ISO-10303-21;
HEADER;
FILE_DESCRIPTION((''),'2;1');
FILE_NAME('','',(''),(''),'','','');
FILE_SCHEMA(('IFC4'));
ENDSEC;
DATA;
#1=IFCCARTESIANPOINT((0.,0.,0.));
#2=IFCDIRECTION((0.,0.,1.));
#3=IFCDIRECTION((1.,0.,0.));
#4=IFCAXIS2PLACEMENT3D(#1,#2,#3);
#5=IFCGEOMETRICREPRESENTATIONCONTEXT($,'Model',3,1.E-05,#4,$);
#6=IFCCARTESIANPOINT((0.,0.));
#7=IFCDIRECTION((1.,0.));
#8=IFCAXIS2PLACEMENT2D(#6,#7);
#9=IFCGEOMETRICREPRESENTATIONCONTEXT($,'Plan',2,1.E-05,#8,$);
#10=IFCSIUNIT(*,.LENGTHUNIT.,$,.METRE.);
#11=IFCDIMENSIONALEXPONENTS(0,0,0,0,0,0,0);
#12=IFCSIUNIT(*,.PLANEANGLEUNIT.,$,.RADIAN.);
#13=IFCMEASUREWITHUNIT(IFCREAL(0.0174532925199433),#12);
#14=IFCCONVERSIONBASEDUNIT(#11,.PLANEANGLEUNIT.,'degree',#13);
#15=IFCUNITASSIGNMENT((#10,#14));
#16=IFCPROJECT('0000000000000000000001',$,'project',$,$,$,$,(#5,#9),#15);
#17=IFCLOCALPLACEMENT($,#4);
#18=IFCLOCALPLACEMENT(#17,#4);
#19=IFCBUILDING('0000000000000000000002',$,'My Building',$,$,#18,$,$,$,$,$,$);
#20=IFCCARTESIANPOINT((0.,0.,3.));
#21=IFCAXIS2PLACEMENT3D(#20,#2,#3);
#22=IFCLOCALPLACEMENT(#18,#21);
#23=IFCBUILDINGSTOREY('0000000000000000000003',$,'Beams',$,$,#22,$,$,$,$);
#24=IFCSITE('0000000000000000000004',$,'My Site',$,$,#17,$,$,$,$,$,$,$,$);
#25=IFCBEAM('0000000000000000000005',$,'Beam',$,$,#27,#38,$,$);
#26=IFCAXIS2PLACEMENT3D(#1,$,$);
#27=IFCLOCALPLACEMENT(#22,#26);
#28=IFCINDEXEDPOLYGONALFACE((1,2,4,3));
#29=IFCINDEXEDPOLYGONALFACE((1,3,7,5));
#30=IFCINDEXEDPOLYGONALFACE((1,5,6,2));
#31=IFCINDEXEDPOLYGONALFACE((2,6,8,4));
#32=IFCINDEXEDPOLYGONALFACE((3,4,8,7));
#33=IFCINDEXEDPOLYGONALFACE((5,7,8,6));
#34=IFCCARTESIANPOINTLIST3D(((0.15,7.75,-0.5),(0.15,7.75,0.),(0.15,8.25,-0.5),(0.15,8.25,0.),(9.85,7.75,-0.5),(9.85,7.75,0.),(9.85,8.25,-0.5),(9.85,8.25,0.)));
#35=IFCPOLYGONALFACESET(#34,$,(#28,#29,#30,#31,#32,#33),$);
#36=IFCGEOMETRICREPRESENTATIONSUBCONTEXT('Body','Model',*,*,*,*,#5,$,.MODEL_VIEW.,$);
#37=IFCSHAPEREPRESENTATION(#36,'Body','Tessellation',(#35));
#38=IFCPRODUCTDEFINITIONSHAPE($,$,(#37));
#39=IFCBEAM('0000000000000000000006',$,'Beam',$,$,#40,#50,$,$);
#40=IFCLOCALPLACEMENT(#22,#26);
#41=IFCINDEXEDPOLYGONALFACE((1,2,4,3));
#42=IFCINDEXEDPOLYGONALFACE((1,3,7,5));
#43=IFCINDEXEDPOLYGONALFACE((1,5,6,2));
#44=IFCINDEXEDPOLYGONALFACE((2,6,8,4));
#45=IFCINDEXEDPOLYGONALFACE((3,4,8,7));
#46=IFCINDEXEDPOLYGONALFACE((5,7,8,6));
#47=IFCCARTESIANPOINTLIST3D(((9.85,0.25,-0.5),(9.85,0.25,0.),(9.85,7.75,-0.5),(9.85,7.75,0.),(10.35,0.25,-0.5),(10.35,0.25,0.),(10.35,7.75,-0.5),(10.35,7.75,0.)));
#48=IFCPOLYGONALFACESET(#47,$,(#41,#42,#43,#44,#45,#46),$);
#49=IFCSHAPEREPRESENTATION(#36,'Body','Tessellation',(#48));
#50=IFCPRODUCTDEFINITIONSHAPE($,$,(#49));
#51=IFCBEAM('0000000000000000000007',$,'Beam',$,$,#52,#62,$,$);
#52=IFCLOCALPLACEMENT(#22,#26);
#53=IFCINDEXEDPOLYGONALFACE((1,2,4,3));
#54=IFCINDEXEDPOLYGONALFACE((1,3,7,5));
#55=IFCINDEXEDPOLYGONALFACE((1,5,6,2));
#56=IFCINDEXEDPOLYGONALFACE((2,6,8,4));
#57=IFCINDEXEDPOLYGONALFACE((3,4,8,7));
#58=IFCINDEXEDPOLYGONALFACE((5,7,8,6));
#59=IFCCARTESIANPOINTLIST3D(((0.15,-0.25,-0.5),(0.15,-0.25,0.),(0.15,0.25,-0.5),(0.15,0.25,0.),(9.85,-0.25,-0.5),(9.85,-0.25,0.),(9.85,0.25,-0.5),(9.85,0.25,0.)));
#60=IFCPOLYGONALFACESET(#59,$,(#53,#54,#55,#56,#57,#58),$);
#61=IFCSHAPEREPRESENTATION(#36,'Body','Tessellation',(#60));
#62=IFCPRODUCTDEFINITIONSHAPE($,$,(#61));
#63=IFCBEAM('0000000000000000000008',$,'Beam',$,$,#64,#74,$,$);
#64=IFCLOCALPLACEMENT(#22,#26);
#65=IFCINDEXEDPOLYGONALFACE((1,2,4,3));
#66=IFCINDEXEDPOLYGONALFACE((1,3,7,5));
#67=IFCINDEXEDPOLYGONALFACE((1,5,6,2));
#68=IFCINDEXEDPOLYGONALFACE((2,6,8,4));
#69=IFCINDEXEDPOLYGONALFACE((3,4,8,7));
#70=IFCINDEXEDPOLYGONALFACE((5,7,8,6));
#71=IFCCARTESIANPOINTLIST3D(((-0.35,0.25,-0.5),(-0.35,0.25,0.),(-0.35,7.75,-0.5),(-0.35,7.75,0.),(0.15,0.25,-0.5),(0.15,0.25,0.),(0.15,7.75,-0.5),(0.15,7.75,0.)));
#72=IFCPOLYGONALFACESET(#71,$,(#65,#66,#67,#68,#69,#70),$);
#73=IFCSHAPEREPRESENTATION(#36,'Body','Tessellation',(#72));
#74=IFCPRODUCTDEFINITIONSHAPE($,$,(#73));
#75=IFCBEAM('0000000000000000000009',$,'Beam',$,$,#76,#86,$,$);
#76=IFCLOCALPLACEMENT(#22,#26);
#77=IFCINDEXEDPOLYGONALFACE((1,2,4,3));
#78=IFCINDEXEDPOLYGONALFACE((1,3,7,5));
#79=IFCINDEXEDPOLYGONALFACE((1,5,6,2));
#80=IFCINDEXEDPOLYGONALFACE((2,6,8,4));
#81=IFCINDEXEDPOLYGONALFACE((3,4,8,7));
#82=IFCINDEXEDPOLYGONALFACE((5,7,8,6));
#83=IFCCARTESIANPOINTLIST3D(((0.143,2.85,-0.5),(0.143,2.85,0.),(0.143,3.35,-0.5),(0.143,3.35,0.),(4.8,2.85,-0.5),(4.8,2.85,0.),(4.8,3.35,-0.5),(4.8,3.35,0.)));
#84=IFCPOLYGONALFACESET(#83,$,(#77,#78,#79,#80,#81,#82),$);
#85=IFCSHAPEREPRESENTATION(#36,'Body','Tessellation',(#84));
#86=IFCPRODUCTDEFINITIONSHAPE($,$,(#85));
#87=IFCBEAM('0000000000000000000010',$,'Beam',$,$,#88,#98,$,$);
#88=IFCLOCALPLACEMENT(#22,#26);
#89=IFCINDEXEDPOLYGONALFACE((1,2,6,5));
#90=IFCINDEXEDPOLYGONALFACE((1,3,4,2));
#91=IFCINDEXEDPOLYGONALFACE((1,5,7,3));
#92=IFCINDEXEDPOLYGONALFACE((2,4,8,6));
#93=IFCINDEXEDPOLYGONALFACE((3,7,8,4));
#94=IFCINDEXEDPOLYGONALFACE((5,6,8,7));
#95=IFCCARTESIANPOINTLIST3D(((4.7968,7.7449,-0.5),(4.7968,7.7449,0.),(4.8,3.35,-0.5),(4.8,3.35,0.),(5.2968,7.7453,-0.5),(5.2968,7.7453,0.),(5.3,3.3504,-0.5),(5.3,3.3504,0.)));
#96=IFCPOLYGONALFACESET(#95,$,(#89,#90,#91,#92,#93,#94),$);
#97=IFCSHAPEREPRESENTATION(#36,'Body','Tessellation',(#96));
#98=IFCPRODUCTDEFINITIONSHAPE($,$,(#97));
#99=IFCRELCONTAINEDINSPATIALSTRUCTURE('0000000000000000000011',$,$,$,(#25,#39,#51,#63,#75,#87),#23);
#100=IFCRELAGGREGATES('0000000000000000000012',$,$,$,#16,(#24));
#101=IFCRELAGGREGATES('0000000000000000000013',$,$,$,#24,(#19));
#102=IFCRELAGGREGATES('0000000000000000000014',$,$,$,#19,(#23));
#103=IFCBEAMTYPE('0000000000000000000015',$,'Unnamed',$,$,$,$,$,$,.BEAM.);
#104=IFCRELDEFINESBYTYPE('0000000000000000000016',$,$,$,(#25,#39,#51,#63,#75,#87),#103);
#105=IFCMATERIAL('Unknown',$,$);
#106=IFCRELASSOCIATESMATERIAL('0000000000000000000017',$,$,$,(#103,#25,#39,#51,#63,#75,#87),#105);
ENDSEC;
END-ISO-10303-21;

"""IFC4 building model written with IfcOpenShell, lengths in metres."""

from ifc_helpers import new_model, entity, si_unit, converted_unit, frame, origin_with_axes, origin_2d_with_axis, place, context, subcontext, project, spatial, rectangle, extrude, material, material_profile, profile_set, profile_usage, type_object, element, save


model = new_model("IFC4")

# Units and contexts
model_context = context("Model", 3, precision=1e-05, world=origin_with_axes())
plan_context = context("Plan", 2, precision=1e-05, world=origin_2d_with_axis())
body_context = subcontext(model_context, "Body", "Model", "MODEL_VIEW")
ifc_project = project(units=[si_unit("LENGTHUNIT", "METRE"), converted_unit("PLANEANGLEUNIT", "degree", entity("IfcReal", 0.0174532925199433), si_unit("PLANEANGLEUNIT", "RADIAN"), dimensions=[0, 0, 0, 0, 0, 0, 0])], contexts=[model_context, plan_context])

# Site, building, storey
site_placement = place(None, origin_with_axes())
site = spatial("IfcSite", under=ifc_project, at=site_placement, Name="My Site")
building_placement = place(site_placement, origin_with_axes())
building = spatial("IfcBuilding", under=site, at=building_placement, Name="My Building")
storey_placement = place(building_placement, frame((0.0, 0.0, 3.0), z_axis=(0.0, 0.0, 1.0), x_axis=(1.0, 0.0, 0.0)))
storey = spatial("IfcBuildingStorey", under=building, at=storey_placement, Name="Beams")

# Beams
ifc_material = material(Name="Unknown")
ifc_material_profile = material_profile(ifc_material, rectangle(XDim=0.5, YDim=0.5))
ifc_profile_set = profile_set([ifc_material_profile])
ifc_profile_usage_1 = profile_usage(ifc_profile_set, cardinal=5)
beam_type = type_object("IfcBeamType", Name="Unnamed", PredefinedType="BEAM", material=ifc_profile_set)
beam_1_placement = place(storey_placement, frame((0.15, 8.0, -0.25), z_axis=(1.0, 0.0, 0.0), x_axis=(0.0, 1.0, 0.0)))
element("IfcBeam", 1, at=beam_1_placement, inside=storey, type_object=beam_type, material=ifc_profile_usage_1, Name="Beam", context=body_context, shape_type="SweptSolid", body=[
    extrude(rectangle(XDim=0.5, YDim=0.5), origin_with_axes(), (0.0, 0.0, 1.0), 9.7),
])
ifc_profile_usage_2 = profile_usage(ifc_profile_set, cardinal=5)
beam_2_placement = place(storey_placement, frame((10.1, 7.75, -0.25), z_axis=(0.0, -1.0, 0.0), x_axis=(1.0, 0.0, 0.0)))
element("IfcBeam", 2, at=beam_2_placement, inside=storey, type_object=beam_type, material=ifc_profile_usage_2, Name="Beam", context=body_context, shape_type="SweptSolid", body=[
    extrude(rectangle(XDim=0.5, YDim=0.5), origin_with_axes(), (0.0, 0.0, 1.0), 7.5),
])
ifc_profile_usage_3 = profile_usage(ifc_profile_set, cardinal=5)
beam_3_placement = place(storey_placement, frame((0.15, 0.0, -0.25), z_axis=(1.0, 0.0, 0.0), x_axis=(0.0, 1.0, 0.0)))
element("IfcBeam", 3, at=beam_3_placement, inside=storey, type_object=beam_type, material=ifc_profile_usage_3, Name="Beam", context=body_context, shape_type="SweptSolid", body=[
    extrude(rectangle(XDim=0.5, YDim=0.5), origin_with_axes(), (0.0, 0.0, 1.0), 9.7),
])
ifc_profile_usage_4 = profile_usage(ifc_profile_set, cardinal=5)
beam_4_placement = place(storey_placement, frame((-0.1, 7.75, -0.25), z_axis=(0.0, -1.0, 0.0), x_axis=(1.0, 0.0, 0.0)))
element("IfcBeam", 4, at=beam_4_placement, inside=storey, type_object=beam_type, material=ifc_profile_usage_4, Name="Beam", context=body_context, shape_type="SweptSolid", body=[
    extrude(rectangle(XDim=0.5, YDim=0.5), origin_with_axes(), (0.0, 0.0, 1.0), 7.5),
])
ifc_profile_usage_5 = profile_usage(ifc_profile_set, cardinal=5)
beam_5_placement = place(storey_placement, frame((4.8, 3.1, -0.25), z_axis=(-1.0, 0.0, 0.0), x_axis=(0.0, -1.0, 0.0)))
element("IfcBeam", 5, at=beam_5_placement, inside=storey, type_object=beam_type, material=ifc_profile_usage_5, Name="Beam", context=body_context, shape_type="SweptSolid", body=[
    extrude(rectangle(XDim=0.5, YDim=0.5), origin_with_axes(), (0.0, 0.0, 1.0), 4.657),
])
ifc_profile_usage_6 = profile_usage(ifc_profile_set, cardinal=5)
beam_6_placement = place(storey_placement, frame((5.05, 3.3502, -0.25), z_axis=(-0.000734, 1.0, 0.0), x_axis=(-1.0, -0.000734, 0.0)))
element("IfcBeam", 6, at=beam_6_placement, inside=storey, type_object=beam_type, material=ifc_profile_usage_6, Name="Beam", context=body_context, shape_type="SweptSolid", body=[
    extrude(rectangle(XDim=0.5, YDim=0.5), origin_with_axes(), (0.0, 0.0, 1.0), 4.395),
])

save(model, "model.ifc")
